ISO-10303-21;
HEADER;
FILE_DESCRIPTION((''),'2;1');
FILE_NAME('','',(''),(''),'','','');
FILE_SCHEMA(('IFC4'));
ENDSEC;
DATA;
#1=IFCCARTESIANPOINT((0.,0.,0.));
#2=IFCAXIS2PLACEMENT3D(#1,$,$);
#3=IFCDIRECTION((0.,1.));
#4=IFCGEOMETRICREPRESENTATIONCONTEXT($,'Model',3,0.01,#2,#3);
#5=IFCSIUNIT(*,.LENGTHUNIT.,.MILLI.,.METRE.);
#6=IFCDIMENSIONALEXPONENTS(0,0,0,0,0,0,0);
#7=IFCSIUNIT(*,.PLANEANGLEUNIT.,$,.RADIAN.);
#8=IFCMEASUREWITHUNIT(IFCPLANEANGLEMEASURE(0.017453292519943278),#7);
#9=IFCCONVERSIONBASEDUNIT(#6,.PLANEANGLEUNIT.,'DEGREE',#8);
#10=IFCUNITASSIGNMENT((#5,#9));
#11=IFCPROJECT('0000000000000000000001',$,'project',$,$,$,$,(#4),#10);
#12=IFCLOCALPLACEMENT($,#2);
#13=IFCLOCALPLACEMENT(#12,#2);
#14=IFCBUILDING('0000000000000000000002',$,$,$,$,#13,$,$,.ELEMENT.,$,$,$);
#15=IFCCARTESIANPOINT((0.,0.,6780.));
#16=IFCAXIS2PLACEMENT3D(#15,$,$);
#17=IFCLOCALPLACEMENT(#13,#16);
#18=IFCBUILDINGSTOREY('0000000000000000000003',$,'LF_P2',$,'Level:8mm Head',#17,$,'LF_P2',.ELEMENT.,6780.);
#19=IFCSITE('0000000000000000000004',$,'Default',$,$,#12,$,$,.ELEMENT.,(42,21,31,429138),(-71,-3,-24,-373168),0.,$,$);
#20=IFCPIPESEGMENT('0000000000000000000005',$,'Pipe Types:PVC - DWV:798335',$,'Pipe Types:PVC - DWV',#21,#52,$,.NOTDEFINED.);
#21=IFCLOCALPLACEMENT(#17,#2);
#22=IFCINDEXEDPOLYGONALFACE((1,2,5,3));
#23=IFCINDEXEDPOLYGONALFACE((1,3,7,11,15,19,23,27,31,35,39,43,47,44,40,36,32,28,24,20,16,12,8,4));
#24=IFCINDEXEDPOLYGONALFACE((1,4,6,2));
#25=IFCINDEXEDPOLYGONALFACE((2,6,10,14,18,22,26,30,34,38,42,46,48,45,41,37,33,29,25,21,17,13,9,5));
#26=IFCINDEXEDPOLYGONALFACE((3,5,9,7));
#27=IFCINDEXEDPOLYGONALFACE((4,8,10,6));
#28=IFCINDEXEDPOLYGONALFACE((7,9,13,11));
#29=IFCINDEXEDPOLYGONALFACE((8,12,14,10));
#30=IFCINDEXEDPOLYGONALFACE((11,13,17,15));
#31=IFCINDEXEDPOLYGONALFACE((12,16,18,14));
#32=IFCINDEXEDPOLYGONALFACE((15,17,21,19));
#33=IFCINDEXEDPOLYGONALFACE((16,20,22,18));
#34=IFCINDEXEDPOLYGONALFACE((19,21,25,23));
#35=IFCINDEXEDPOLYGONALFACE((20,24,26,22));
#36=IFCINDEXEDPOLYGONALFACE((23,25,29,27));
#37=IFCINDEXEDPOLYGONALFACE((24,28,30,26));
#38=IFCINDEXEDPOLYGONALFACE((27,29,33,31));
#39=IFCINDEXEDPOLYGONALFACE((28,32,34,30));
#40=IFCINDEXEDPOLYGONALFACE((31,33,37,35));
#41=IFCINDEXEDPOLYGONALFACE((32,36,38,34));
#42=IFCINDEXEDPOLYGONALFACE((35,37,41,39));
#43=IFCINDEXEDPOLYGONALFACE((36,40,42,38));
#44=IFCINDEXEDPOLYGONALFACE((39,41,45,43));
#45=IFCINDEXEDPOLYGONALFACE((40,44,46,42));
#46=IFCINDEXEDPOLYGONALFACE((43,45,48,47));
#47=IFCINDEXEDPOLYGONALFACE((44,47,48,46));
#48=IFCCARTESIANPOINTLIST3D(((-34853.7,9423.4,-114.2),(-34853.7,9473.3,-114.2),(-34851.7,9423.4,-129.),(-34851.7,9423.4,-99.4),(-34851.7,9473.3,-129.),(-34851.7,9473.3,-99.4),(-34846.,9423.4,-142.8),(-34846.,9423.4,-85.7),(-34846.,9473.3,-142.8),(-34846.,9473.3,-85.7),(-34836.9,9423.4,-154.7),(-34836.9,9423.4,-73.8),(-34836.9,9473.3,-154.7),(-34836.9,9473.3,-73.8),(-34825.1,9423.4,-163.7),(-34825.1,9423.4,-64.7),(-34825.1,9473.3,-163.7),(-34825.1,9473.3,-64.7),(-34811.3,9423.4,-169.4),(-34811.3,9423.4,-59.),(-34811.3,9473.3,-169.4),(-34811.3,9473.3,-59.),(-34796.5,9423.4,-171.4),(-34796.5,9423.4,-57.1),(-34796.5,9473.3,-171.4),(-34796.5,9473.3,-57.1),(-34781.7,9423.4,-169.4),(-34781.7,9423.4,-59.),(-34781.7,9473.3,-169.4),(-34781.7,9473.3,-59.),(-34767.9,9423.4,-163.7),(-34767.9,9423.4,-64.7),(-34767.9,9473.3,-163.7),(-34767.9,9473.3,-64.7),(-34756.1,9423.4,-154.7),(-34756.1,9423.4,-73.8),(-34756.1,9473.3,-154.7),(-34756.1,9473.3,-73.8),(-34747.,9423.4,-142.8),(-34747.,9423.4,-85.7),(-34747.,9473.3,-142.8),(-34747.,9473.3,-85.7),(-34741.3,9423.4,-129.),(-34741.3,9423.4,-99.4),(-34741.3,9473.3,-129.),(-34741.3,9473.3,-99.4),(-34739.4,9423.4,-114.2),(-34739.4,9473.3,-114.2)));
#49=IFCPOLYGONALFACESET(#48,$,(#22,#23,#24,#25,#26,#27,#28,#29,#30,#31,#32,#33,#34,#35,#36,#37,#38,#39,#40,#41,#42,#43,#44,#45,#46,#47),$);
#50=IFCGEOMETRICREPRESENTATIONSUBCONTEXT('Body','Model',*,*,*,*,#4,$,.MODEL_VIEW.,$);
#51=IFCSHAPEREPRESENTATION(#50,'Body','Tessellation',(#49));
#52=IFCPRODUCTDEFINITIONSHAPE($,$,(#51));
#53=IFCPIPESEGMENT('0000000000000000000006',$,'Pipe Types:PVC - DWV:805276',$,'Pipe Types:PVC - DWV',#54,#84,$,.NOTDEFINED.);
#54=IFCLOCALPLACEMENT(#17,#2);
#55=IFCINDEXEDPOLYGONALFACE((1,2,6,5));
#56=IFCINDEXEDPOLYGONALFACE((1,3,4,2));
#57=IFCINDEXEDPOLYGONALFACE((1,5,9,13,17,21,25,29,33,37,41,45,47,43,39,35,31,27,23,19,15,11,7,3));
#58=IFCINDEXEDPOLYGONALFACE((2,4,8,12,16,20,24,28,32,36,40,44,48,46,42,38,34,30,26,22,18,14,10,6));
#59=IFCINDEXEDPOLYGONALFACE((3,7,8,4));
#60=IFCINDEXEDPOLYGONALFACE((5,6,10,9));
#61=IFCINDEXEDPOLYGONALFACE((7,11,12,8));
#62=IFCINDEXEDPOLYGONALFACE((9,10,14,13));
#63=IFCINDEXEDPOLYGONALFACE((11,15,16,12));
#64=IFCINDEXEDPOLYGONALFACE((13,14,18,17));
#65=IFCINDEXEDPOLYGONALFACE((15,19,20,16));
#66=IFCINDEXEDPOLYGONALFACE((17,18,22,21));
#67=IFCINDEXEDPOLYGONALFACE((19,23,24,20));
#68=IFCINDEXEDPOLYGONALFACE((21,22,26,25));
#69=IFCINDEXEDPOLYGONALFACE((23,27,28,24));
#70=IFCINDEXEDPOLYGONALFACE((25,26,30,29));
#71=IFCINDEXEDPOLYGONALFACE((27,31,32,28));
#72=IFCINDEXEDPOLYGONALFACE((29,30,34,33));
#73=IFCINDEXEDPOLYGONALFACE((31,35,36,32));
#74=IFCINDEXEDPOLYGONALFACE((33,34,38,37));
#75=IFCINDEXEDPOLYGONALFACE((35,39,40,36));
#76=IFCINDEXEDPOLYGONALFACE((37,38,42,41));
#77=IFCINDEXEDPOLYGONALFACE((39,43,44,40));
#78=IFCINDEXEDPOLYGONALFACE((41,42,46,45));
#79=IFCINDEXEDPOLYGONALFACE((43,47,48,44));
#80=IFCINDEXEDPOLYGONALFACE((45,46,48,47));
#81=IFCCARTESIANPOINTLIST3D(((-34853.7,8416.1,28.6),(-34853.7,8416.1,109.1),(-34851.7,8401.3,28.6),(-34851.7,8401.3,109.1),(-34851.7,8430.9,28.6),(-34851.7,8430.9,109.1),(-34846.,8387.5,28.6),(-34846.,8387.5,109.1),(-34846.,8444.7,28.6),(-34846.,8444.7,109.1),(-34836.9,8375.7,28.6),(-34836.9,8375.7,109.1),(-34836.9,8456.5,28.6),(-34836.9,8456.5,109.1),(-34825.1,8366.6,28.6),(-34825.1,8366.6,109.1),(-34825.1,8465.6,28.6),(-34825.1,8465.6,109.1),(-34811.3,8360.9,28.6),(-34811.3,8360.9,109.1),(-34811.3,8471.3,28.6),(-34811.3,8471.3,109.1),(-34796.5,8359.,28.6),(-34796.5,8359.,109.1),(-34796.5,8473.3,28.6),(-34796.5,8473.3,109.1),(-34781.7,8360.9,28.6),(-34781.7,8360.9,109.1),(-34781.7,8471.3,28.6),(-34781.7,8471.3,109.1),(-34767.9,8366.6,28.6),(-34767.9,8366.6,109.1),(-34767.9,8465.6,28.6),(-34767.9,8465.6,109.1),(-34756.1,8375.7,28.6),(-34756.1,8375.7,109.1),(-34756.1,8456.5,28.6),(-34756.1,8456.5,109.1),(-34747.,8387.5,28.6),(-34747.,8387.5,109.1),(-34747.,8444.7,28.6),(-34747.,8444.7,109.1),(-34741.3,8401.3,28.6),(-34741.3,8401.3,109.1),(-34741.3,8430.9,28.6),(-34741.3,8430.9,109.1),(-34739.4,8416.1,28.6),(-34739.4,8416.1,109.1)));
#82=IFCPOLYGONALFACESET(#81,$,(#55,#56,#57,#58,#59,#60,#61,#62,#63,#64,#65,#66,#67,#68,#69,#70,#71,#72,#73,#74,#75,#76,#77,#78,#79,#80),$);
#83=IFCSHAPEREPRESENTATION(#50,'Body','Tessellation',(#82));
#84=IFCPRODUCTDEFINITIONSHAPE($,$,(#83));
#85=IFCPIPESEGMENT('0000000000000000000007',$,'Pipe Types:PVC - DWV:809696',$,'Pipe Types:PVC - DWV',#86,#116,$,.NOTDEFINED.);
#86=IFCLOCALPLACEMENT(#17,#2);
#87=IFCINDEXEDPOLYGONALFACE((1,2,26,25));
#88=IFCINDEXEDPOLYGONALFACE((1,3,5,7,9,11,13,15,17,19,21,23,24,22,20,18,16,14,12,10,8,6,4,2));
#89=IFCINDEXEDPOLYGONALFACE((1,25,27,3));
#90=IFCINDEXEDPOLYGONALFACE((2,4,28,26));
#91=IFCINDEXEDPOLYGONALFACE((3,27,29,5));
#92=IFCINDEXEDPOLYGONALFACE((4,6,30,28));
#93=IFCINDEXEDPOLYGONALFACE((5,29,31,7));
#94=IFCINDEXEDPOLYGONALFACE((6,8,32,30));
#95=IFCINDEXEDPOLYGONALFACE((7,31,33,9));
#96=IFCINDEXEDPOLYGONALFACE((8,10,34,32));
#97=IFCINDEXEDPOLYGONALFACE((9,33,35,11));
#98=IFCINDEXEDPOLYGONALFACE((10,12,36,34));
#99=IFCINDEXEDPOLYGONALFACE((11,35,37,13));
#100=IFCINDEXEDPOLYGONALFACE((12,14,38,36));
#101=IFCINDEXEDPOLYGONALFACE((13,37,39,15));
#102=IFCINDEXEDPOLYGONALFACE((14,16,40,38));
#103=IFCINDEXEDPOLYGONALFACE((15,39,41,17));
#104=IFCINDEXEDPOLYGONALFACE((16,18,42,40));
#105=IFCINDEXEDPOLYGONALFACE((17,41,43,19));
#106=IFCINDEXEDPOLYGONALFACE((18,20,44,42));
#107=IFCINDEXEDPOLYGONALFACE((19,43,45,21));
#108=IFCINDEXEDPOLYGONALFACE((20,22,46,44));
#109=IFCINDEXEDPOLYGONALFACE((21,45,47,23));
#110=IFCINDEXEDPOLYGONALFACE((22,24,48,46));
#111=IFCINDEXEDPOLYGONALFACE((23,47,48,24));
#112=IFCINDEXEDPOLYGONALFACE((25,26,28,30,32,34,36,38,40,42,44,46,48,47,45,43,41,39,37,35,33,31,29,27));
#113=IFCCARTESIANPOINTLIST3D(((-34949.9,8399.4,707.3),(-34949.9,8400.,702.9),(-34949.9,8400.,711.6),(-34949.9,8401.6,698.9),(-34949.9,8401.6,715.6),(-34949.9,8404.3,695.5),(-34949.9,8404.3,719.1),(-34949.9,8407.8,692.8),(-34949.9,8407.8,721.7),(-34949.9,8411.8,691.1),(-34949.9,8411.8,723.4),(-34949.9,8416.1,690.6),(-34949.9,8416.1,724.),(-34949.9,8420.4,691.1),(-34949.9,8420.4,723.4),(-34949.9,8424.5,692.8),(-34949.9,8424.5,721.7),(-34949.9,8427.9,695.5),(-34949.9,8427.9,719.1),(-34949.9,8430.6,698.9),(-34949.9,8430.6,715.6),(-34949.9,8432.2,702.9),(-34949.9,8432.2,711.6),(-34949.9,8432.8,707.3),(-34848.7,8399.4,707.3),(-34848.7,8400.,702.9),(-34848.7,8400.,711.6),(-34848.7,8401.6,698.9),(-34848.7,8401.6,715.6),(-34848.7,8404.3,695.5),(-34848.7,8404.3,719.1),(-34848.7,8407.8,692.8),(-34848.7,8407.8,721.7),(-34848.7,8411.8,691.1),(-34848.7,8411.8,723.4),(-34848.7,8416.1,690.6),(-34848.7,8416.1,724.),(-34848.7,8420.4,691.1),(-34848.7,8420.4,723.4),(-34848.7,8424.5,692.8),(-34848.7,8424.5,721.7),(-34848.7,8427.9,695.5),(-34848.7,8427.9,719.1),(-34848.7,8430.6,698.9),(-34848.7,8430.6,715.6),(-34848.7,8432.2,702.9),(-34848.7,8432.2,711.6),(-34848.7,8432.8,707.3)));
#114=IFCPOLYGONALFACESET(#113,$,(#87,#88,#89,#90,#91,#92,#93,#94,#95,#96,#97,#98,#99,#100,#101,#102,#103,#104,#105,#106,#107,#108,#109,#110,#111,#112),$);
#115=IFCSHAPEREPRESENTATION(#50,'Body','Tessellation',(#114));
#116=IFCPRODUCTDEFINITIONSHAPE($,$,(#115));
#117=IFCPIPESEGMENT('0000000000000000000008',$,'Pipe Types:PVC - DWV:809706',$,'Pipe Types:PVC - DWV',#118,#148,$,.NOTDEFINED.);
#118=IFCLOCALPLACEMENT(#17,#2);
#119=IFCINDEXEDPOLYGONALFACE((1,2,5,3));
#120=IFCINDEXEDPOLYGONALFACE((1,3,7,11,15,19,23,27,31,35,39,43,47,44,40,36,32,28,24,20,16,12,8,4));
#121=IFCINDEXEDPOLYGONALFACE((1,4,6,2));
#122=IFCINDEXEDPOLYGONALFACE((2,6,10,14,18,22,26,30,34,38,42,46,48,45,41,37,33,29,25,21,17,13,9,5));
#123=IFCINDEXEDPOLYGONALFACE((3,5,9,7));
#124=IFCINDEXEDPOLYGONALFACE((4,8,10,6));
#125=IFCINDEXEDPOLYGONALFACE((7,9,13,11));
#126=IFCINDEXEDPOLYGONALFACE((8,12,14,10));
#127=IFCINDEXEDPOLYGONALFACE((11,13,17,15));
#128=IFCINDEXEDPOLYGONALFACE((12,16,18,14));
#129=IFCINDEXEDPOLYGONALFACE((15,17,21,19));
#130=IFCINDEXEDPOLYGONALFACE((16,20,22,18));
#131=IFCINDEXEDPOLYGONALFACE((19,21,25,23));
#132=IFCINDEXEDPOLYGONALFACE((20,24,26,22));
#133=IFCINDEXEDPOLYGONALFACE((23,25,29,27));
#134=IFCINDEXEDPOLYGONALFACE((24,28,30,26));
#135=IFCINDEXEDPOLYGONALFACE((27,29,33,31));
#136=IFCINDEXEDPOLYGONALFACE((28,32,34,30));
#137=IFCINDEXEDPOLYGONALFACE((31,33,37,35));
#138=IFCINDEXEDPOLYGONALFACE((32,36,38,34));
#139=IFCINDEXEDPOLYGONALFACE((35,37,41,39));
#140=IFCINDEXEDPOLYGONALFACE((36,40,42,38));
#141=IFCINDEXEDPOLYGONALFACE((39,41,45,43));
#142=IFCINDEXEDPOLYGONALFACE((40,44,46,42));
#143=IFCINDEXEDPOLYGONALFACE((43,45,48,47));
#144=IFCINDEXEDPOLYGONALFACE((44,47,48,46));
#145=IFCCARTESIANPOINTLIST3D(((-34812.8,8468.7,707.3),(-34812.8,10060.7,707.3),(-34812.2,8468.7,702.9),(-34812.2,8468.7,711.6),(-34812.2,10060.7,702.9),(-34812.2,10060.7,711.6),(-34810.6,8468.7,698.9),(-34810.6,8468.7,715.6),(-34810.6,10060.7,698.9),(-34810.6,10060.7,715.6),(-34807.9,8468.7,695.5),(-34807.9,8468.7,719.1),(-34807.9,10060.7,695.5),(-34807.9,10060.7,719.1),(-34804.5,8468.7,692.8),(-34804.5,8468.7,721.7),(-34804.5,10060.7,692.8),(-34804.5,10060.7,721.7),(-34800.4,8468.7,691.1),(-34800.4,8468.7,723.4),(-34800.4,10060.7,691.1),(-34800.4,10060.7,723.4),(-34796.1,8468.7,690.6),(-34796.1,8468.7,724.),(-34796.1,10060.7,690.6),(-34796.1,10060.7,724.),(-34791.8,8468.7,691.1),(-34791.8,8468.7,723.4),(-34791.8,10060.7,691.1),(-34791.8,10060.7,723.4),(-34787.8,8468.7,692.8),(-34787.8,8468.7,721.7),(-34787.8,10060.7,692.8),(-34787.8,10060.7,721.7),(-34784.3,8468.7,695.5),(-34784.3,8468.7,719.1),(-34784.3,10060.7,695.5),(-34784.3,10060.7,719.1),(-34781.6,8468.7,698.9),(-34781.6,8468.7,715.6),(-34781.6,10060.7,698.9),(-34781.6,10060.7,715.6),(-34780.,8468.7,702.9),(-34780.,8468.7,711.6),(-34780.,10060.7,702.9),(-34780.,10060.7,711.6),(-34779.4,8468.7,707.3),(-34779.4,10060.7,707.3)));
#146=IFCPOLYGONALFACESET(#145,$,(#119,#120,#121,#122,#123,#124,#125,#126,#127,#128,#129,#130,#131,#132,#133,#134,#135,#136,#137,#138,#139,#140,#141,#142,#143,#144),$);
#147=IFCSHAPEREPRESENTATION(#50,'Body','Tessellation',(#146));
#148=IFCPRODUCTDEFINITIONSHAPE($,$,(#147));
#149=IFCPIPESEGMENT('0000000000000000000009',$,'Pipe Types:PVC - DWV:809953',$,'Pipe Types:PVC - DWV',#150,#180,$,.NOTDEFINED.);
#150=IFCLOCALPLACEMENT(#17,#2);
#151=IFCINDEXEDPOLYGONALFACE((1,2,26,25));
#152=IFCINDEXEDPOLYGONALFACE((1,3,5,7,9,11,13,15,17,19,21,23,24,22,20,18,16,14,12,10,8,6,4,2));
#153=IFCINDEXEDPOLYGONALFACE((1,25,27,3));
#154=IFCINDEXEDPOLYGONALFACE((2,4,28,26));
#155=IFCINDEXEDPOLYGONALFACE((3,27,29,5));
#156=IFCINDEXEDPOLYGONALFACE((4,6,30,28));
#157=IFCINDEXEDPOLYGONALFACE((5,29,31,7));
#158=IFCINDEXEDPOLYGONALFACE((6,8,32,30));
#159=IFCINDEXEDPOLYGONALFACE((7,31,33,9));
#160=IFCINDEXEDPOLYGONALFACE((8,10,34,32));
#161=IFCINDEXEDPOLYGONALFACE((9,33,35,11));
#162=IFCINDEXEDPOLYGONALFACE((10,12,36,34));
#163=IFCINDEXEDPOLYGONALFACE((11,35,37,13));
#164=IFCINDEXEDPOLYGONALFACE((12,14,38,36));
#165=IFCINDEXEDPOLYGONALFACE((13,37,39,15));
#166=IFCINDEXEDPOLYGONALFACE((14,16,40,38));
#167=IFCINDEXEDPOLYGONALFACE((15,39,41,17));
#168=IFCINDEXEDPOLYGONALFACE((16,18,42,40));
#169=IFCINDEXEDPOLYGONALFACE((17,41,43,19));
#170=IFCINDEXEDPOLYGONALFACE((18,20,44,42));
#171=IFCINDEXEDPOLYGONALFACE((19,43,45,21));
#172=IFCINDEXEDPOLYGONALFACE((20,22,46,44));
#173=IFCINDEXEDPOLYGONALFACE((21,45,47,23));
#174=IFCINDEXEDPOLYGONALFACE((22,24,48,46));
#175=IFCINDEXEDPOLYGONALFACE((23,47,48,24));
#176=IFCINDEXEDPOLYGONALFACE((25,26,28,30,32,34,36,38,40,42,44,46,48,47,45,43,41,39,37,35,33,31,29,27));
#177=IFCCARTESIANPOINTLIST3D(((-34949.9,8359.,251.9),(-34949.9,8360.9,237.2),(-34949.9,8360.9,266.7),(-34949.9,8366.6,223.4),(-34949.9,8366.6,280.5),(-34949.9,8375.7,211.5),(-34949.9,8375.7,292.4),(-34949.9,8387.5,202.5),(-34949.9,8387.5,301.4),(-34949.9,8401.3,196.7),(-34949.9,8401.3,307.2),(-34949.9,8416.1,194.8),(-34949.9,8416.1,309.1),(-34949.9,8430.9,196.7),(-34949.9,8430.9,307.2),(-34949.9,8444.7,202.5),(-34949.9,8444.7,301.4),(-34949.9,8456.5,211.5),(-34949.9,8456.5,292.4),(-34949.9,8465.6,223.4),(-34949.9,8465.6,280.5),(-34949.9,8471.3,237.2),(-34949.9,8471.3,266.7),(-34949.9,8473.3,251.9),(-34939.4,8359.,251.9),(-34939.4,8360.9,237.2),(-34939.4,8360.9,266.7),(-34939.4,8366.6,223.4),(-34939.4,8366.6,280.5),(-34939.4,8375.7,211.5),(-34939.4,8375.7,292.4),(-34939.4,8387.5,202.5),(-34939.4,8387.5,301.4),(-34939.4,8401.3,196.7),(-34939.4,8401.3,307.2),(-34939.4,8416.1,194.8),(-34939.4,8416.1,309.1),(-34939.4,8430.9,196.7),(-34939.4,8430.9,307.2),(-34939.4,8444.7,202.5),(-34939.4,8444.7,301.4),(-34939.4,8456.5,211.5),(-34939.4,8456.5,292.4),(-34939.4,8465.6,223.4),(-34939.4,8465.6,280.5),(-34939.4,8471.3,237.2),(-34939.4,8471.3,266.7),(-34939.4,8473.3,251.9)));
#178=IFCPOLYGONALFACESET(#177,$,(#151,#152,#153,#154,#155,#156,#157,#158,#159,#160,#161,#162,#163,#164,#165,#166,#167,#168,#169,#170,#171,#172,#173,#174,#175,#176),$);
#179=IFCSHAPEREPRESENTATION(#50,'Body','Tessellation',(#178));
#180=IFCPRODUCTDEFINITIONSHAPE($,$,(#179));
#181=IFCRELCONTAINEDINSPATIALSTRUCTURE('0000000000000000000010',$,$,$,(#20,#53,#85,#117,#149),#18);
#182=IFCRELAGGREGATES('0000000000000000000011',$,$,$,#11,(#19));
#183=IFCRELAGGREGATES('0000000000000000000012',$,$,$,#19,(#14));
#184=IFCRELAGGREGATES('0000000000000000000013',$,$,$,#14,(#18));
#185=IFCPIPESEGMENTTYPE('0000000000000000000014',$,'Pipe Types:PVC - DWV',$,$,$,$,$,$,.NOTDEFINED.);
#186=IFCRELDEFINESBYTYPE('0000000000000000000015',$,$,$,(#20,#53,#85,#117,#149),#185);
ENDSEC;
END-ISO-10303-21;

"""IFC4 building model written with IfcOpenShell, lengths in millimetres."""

from ifc_helpers import new_model, entity, si_unit, converted_unit, direction, frame, origin, place, context, subcontext, project, spatial, arc, indexed_curve, outline, extrude, type_object, element, save


model = new_model("IFC4")

# Units and contexts
model_context = context("Model", 3, precision=0.01, world=origin(), true_north=direction((0.0, 1.0)))
body_context = subcontext(model_context, "Body", "Model", "MODEL_VIEW")
ifc_project = project(units=[si_unit("LENGTHUNIT", "METRE", prefix="MILLI"), converted_unit("PLANEANGLEUNIT", "DEGREE", entity("IfcPlaneAngleMeasure", 0.017453292519943278), si_unit("PLANEANGLEUNIT", "RADIAN"), dimensions=[0, 0, 0, 0, 0, 0, 0])], contexts=[model_context])

# Site, building, storey
site_placement = place(None, origin())
site = spatial("IfcSite", under=ifc_project, at=site_placement, Name="Default", CompositionType="ELEMENT", RefLatitude=(42, 21, 31, 429138), RefLongitude=(-71, -3, -24, -373168), RefElevation=0.0)
building_placement = place(site_placement, origin())
building = spatial("IfcBuilding", under=site, at=building_placement, CompositionType="ELEMENT")
storey_placement = place(building_placement, frame((0.0, 0.0, 6780.0)))
storey = spatial("IfcBuildingStorey", under=building, at=storey_placement, Name="LF_P2", ObjectType="Level:8mm Head", LongName="LF_P2", CompositionType="ELEMENT", Elevation=6780.0)

# Pipe segments
pipe_segment_type_1 = type_object("IfcPipeSegmentType", Name="Pipe Types:PVC - DWV", PredefinedType="NOTDEFINED")
pipe_segment_1_placement = place(storey_placement, origin())
element("IfcPipeSegment", 1, at=pipe_segment_1_placement, inside=storey, type_object=pipe_segment_type_1, Name="Pipe Types:PVC - DWV:798335", ObjectType="Pipe Types:PVC - DWV", PredefinedType="NOTDEFINED", context=body_context, shape_type="SweptSolid", body=[
    extrude(outline(indexed_curve([(57.2, 0.0), (40.4, 40.4), (0.0, 57.2), (-40.4, 40.4), (-57.2, 0.0), (-40.4, -40.4), (0.0, -57.2), (40.4, -40.4)], segments=[arc(1, 2, 3), arc(3, 4, 5), arc(5, 6, 7), arc(7, 8, 1)], self_intersect=False)), frame((-34796.5, 9423.4, -114.2), z_axis=(0.0, 1.0, 0.0), x_axis=(1.0, 0.0, 0.0)), (0.0, 0.0, 1.0), 49.9),
])
pipe_segment_2_placement = place(storey_placement, origin())
element("IfcPipeSegment", 2, at=pipe_segment_2_placement, inside=storey, type_object=pipe_segment_type_1, Name="Pipe Types:PVC - DWV:805276", ObjectType="Pipe Types:PVC - DWV", PredefinedType="NOTDEFINED", context=body_context, shape_type="SweptSolid", body=[
    extrude(outline(indexed_curve([(57.2, 0.0), (40.4, 40.4), (0.0, 57.2), (-40.4, 40.4), (-57.2, 0.0), (-40.4, -40.4), (0.0, -57.2), (40.4, -40.4)], segments=[arc(1, 2, 3), arc(3, 4, 5), arc(5, 6, 7), arc(7, 8, 1)], self_intersect=False)), frame((-34796.5, 8416.1, 28.6), z_axis=(0.0, 0.0, 1.0), x_axis=(-1.0, 0.0, 0.0)), (0.0, 0.0, 1.0), 80.4),
])
pipe_segment_3_placement = place(storey_placement, origin())
element("IfcPipeSegment", 3, at=pipe_segment_3_placement, inside=storey, type_object=pipe_segment_type_1, Name="Pipe Types:PVC - DWV:809696", ObjectType="Pipe Types:PVC - DWV", PredefinedType="NOTDEFINED", context=body_context, shape_type="SweptSolid", body=[
    extrude(outline(indexed_curve([(16.7, 0.0), (11.8, 11.8), (0.0, 16.7), (-11.8, 11.8), (-16.7, 0.0), (-11.8, -11.8), (0.0, -16.7), (11.8, -11.8)], segments=[arc(1, 2, 3), arc(3, 4, 5), arc(5, 6, 7), arc(7, 8, 1)], self_intersect=False)), frame((-34949.9, 8416.1, 707.3), z_axis=(1.0, 0.0, 0.0), x_axis=(0.0, 1.0, 0.0)), (0.0, 0.0, 1.0), 101.1),
])
pipe_segment_4_placement = place(storey_placement, origin())
element("IfcPipeSegment", 4, at=pipe_segment_4_placement, inside=storey, type_object=pipe_segment_type_1, Name="Pipe Types:PVC - DWV:809706", ObjectType="Pipe Types:PVC - DWV", PredefinedType="NOTDEFINED", context=body_context, shape_type="SweptSolid", body=[
    extrude(outline(indexed_curve([(16.7, 0.0), (11.8, 11.8), (0.0, 16.7), (-11.8, 11.8), (-16.7, 0.0), (-11.8, -11.8), (0.0, -16.7), (11.8, -11.8)], segments=[arc(1, 2, 3), arc(3, 4, 5), arc(5, 6, 7), arc(7, 8, 1)], self_intersect=False)), frame((-34796.1, 8468.7, 707.3), z_axis=(0.0, 1.0, 0.0), x_axis=(1.0, 0.0, 0.0)), (0.0, 0.0, 1.0), 1592.0),
])
pipe_segment_5_placement = place(storey_placement, origin())
element("IfcPipeSegment", 5, at=pipe_segment_5_placement, inside=storey, type_object=pipe_segment_type_1, Name="Pipe Types:PVC - DWV:809953", ObjectType="Pipe Types:PVC - DWV", PredefinedType="NOTDEFINED", context=body_context, shape_type="SweptSolid", body=[
    extrude(outline(indexed_curve([(57.2, 0.0), (40.4, 40.4), (0.0, 57.2), (-40.4, 40.4), (-57.2, 0.0), (-40.4, -40.4), (0.0, -57.2), (40.4, -40.4)], segments=[arc(1, 2, 3), arc(3, 4, 5), arc(5, 6, 7), arc(7, 8, 1)], self_intersect=False)), frame((-34949.9, 8416.1, 252.0), z_axis=(1.0, 0.0, 0.0), x_axis=(0.0, 1.0, 0.0)), (0.0, 0.0, 1.0), 10.5),
])

save(model, "model.ifc")
